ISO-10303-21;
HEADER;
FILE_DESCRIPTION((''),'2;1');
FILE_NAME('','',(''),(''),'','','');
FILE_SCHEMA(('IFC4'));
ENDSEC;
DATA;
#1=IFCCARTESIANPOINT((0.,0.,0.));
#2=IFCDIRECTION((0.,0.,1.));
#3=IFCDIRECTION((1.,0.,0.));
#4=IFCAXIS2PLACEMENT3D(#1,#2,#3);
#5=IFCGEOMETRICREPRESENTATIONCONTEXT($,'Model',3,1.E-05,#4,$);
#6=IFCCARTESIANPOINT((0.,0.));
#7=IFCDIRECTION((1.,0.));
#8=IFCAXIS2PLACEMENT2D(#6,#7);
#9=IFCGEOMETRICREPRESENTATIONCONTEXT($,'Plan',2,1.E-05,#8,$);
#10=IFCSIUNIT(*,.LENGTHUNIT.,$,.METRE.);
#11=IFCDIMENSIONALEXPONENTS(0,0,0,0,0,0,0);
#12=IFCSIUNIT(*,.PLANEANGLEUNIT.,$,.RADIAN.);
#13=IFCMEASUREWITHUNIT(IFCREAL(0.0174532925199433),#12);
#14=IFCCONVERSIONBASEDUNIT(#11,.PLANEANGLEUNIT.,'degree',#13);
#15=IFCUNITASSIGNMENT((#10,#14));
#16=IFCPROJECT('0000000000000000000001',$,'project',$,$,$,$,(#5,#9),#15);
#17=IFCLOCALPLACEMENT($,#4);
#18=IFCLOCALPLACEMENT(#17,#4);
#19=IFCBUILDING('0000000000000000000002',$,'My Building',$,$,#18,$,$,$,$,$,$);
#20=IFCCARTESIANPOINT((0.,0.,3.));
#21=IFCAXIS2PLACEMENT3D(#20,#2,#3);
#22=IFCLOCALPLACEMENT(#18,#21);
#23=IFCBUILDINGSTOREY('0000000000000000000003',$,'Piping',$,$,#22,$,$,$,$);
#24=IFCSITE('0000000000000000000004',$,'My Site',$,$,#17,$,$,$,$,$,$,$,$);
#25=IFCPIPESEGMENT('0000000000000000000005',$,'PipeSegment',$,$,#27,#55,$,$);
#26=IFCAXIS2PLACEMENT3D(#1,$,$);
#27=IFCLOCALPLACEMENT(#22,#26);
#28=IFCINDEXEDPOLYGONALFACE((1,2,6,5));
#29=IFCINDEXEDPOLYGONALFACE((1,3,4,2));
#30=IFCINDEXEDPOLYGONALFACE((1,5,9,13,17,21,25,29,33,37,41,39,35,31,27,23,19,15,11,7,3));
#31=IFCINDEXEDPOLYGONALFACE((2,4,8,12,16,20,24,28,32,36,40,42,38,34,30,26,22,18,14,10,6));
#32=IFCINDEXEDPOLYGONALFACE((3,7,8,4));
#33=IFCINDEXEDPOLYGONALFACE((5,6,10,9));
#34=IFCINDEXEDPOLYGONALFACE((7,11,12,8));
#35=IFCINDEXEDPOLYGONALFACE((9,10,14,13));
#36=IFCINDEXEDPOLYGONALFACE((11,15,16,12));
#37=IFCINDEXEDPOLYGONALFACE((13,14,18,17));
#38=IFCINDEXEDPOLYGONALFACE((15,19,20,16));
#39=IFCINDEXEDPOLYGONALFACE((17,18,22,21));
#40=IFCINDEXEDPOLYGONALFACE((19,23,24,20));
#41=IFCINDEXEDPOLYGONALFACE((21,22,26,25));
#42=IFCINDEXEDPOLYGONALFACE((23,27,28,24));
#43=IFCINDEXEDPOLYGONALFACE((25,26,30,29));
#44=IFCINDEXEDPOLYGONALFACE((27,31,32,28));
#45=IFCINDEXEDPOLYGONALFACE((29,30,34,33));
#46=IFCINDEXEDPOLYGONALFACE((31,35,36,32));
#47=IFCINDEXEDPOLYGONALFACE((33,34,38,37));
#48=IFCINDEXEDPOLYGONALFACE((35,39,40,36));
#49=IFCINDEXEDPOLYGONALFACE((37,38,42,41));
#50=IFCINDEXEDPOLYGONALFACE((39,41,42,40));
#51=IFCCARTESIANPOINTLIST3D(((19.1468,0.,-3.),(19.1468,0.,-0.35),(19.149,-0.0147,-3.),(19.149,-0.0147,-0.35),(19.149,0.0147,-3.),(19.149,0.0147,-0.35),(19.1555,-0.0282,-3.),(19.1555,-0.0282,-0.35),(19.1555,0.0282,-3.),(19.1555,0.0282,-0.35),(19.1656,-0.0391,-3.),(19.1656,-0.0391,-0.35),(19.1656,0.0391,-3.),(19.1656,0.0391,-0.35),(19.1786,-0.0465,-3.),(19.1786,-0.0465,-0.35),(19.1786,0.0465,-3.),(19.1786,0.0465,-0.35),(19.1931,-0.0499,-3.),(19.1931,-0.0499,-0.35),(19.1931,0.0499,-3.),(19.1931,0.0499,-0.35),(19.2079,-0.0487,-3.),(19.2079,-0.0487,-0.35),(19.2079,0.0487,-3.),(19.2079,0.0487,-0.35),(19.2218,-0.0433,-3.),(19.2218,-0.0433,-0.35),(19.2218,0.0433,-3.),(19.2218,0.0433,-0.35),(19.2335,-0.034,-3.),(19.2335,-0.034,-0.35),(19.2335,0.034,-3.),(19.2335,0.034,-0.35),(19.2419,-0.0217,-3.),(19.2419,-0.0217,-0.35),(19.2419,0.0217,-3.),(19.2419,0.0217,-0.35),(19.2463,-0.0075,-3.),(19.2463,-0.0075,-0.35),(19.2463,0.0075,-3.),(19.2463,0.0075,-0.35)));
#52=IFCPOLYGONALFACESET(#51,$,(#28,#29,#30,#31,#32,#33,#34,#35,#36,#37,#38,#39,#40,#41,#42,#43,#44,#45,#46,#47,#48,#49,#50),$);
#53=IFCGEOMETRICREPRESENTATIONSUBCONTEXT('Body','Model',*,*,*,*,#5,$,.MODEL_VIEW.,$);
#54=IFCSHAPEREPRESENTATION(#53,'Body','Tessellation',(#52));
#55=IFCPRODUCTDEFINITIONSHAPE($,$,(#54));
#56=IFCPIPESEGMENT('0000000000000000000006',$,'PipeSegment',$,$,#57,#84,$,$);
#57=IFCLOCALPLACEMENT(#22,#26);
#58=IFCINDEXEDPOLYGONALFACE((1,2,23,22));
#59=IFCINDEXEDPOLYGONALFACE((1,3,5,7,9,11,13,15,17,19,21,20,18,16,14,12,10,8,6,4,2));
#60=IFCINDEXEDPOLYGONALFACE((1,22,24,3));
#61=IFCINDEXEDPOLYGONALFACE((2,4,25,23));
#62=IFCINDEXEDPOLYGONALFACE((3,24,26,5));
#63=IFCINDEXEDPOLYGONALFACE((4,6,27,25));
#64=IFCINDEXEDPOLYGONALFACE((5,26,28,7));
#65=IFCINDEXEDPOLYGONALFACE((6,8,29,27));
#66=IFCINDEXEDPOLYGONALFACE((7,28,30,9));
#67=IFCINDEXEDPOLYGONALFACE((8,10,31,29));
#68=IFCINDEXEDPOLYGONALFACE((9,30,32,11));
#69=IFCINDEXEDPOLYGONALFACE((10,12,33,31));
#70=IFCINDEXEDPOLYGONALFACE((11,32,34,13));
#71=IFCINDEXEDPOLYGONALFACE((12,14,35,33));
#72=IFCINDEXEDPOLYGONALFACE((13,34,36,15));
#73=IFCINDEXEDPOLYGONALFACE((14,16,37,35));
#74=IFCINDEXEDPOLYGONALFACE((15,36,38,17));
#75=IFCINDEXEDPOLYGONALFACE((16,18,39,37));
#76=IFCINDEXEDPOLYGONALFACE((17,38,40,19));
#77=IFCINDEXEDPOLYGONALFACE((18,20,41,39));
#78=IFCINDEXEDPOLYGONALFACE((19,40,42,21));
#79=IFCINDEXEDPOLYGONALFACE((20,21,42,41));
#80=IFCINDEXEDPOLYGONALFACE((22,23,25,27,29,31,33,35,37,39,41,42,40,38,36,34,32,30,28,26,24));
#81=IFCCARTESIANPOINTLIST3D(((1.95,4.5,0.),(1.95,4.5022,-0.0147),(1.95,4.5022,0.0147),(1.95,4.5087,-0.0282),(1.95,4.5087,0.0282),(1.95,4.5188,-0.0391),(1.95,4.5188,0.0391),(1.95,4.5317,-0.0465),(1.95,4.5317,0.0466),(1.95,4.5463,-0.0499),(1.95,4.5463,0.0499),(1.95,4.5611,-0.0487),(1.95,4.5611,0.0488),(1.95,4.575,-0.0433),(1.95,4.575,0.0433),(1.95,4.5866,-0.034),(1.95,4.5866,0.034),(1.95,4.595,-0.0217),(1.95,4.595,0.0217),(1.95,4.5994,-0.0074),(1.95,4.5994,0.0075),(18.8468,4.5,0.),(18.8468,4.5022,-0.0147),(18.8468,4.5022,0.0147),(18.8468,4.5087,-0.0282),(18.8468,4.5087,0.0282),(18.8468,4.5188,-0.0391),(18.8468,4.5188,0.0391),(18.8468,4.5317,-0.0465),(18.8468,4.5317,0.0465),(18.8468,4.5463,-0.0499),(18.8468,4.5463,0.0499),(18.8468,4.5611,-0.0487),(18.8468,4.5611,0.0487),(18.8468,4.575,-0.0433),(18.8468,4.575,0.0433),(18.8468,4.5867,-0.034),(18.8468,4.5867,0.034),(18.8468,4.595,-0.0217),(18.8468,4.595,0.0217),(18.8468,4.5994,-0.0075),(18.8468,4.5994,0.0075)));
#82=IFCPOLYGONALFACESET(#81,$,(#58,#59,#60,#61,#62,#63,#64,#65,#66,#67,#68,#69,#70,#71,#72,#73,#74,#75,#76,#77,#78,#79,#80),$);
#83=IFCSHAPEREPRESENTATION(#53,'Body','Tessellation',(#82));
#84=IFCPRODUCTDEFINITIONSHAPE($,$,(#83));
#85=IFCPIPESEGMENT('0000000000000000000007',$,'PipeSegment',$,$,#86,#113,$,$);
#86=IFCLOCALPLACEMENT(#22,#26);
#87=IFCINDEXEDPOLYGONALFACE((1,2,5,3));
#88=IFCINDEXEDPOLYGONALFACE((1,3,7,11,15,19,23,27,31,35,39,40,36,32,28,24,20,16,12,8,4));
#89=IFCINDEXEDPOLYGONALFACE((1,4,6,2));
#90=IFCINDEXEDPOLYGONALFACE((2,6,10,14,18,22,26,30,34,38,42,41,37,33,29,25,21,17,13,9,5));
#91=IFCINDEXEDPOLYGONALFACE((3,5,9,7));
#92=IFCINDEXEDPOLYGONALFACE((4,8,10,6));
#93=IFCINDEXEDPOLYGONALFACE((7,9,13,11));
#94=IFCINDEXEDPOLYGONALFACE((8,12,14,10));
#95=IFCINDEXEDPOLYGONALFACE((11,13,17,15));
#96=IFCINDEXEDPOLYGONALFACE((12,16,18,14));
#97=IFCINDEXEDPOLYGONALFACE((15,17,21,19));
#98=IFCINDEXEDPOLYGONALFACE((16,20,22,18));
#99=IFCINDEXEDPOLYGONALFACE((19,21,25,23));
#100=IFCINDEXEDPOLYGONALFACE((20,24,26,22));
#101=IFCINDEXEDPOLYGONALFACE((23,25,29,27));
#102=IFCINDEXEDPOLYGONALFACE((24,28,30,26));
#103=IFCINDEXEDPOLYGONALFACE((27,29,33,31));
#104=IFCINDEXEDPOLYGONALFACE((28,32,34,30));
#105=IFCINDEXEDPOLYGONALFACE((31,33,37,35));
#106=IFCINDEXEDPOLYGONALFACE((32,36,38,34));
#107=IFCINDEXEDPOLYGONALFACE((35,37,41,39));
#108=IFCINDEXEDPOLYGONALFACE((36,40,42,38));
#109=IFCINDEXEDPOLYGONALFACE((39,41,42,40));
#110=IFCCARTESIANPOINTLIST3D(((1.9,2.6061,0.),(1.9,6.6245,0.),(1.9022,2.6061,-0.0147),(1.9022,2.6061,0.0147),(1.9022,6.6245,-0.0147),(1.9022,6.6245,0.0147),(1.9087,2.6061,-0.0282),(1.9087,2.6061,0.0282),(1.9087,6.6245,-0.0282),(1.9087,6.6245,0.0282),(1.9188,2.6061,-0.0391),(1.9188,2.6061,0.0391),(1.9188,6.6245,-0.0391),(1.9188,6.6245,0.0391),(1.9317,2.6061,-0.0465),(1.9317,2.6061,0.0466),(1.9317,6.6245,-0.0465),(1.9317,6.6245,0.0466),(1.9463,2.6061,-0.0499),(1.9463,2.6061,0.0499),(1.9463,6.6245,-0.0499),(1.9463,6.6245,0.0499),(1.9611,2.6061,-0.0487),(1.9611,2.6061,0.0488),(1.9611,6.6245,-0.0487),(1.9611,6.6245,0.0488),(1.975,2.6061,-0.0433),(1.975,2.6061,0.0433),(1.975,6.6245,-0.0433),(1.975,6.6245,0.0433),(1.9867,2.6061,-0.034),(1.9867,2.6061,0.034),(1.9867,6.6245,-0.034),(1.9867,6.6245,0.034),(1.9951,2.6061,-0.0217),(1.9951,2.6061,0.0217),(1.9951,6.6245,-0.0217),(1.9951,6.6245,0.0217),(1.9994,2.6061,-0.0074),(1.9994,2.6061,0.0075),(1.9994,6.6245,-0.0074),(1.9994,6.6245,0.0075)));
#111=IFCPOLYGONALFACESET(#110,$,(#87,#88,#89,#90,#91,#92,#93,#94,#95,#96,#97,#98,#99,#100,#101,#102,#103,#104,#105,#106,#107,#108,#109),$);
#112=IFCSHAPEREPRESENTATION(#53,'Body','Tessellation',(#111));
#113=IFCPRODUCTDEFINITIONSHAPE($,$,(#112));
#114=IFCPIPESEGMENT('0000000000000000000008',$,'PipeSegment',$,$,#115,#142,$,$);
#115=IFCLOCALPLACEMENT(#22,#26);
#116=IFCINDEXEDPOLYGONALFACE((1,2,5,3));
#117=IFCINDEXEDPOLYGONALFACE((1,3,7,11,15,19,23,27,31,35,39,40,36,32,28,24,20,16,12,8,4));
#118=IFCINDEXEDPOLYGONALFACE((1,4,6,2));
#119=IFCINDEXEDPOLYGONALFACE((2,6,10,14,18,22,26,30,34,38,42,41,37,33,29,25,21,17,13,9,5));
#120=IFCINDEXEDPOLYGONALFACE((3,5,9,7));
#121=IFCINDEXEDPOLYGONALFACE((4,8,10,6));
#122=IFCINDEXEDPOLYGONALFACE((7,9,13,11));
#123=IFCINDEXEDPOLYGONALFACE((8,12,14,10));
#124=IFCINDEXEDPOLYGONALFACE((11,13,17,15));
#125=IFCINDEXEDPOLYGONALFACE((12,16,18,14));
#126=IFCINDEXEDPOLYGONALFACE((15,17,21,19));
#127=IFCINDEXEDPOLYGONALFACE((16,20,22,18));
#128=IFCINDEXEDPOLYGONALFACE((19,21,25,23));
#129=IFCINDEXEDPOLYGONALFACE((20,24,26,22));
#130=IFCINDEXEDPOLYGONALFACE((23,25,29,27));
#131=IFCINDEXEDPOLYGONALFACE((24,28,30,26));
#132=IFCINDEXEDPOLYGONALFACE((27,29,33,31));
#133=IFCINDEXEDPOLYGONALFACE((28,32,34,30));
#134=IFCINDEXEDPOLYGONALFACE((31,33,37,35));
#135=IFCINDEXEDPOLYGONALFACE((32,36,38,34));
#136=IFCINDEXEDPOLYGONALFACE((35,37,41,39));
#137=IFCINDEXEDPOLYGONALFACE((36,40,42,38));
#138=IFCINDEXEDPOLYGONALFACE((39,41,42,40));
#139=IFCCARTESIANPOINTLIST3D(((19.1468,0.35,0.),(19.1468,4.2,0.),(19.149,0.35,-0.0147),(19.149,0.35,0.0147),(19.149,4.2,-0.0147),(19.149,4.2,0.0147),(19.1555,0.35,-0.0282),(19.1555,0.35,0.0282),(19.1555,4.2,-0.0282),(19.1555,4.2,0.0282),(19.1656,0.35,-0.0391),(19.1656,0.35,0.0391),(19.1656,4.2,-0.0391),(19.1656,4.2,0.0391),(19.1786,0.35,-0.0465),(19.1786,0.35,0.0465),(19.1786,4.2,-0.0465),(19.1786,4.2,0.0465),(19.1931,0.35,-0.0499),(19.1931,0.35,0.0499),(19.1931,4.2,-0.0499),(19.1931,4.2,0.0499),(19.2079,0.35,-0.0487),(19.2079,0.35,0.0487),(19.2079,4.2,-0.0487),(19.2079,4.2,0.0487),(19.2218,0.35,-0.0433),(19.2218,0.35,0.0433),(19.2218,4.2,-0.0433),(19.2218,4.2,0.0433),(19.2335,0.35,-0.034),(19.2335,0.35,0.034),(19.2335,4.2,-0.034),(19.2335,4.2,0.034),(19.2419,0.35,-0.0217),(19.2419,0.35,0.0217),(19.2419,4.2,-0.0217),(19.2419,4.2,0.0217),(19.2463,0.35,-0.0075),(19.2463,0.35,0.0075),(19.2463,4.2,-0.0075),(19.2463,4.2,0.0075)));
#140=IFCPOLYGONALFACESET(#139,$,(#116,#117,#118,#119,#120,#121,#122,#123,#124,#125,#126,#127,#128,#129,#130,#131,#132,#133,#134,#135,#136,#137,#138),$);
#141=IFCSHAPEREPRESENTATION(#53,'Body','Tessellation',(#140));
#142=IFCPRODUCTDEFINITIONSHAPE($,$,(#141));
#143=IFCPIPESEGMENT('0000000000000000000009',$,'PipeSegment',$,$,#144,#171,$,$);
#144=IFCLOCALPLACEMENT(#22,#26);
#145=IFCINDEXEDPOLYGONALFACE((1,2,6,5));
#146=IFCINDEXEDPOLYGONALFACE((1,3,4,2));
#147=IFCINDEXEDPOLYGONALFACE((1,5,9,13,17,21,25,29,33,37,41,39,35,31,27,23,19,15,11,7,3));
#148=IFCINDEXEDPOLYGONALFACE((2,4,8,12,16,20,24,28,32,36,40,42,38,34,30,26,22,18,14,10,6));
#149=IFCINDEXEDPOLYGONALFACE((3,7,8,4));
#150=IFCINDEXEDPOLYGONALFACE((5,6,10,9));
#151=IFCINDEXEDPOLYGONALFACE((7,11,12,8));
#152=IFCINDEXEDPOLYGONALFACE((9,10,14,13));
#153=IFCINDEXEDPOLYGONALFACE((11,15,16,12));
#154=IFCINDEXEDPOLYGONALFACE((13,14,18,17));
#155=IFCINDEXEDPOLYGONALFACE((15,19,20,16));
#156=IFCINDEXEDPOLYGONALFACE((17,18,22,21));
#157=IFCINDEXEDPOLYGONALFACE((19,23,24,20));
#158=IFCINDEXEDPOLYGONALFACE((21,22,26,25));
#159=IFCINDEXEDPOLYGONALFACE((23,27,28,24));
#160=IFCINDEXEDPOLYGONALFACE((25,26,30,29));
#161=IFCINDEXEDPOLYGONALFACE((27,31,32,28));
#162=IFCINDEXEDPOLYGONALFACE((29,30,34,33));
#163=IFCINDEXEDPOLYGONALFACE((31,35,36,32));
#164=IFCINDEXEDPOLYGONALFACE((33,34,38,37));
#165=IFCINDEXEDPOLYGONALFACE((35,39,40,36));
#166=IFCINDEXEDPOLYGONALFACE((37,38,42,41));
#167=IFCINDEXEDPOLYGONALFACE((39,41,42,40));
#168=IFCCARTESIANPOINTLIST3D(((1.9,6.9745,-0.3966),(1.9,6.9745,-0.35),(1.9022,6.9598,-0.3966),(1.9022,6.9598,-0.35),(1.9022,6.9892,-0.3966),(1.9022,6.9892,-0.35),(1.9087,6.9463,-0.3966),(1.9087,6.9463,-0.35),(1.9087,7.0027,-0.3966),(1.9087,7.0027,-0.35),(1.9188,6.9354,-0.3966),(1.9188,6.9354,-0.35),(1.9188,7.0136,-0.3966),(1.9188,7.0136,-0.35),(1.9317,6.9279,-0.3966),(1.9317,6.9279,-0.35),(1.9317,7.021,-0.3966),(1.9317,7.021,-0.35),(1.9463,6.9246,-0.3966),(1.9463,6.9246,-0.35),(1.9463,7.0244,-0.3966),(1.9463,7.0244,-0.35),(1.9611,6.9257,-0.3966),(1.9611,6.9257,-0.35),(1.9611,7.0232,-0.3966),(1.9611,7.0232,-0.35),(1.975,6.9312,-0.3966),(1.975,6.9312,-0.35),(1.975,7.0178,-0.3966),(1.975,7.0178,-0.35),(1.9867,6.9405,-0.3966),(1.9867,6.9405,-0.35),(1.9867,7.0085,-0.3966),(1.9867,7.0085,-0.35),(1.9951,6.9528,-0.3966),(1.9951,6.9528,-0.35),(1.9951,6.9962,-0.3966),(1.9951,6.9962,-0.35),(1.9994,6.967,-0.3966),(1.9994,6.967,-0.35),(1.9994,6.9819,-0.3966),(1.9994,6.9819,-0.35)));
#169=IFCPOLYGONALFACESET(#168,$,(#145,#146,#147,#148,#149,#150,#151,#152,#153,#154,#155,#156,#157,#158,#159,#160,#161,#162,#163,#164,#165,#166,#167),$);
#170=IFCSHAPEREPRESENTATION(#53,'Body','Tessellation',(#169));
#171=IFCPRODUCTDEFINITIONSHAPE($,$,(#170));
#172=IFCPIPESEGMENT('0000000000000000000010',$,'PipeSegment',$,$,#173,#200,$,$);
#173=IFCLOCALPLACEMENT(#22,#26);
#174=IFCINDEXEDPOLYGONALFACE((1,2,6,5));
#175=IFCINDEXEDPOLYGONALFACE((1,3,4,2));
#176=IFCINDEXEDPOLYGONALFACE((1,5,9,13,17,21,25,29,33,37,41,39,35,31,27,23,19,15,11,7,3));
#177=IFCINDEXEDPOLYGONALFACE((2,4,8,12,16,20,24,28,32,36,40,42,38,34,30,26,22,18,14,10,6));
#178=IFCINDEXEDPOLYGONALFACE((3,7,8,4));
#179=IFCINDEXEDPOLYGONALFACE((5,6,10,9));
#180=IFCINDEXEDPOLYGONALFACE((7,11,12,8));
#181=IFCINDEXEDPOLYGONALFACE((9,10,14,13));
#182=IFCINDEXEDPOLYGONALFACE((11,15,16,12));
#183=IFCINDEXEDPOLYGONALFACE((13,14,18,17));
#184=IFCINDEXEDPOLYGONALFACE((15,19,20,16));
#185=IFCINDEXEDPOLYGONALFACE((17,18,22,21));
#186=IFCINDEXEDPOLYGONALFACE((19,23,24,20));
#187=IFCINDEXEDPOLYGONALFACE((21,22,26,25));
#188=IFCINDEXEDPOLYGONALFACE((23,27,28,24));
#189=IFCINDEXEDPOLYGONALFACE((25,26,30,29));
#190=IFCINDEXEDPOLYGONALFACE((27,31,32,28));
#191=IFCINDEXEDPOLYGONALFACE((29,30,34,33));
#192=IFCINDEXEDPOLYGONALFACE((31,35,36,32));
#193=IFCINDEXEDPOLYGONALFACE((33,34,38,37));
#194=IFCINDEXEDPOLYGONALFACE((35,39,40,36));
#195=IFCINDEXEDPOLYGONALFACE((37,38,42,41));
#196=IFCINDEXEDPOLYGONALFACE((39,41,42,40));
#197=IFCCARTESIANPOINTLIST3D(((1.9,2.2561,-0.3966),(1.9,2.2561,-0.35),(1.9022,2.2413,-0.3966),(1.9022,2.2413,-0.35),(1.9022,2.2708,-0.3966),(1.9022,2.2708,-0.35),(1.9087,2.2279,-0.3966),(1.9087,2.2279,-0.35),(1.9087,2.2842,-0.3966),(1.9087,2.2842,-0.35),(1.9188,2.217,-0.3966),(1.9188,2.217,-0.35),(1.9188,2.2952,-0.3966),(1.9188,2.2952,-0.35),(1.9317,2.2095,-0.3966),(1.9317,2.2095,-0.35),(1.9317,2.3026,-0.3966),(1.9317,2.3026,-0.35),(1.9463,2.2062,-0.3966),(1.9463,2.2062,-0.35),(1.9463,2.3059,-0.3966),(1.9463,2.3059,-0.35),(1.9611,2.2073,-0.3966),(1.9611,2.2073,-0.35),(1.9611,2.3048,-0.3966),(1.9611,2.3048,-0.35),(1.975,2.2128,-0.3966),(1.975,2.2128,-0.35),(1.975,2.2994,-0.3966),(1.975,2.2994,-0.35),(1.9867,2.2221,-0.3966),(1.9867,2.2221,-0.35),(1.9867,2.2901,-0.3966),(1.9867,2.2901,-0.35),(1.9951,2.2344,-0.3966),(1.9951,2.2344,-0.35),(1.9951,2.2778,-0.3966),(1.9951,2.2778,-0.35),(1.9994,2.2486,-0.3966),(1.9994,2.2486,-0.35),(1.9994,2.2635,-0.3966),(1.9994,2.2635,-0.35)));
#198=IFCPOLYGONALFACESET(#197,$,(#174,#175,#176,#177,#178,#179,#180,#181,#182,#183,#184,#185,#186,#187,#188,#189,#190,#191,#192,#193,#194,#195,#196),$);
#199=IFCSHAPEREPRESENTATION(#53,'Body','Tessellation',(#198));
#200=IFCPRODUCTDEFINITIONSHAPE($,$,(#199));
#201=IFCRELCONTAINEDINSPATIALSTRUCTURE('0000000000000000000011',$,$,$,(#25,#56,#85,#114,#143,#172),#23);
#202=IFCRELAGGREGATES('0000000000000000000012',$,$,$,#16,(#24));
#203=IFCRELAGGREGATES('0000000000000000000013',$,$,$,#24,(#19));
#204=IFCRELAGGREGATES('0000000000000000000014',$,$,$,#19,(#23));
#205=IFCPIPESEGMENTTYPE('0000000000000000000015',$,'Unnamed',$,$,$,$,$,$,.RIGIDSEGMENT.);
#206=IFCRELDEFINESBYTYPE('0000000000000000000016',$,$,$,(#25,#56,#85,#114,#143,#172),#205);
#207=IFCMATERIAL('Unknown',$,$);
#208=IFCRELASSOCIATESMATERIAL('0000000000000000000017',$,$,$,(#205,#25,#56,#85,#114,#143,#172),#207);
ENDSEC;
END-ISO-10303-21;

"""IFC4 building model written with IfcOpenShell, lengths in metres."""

from ifc_helpers import new_model, entity, si_unit, converted_unit, frame, origin_with_axes, origin_2d_with_axis, place, context, subcontext, project, spatial, circle, extrude, material, material_profile, profile_set, profile_usage, type_object, element, save


model = new_model("IFC4")

# Units and contexts
model_context = context("Model", 3, precision=1e-05, world=origin_with_axes())
plan_context = context("Plan", 2, precision=1e-05, world=origin_2d_with_axis())
body_context = subcontext(model_context, "Body", "Model", "MODEL_VIEW")
ifc_project = project(units=[si_unit("LENGTHUNIT", "METRE"), converted_unit("PLANEANGLEUNIT", "degree", entity("IfcReal", 0.0174532925199433), si_unit("PLANEANGLEUNIT", "RADIAN"), dimensions=[0, 0, 0, 0, 0, 0, 0])], contexts=[model_context, plan_context])

# Site, building, storey
site_placement = place(None, origin_with_axes())
site = spatial("IfcSite", under=ifc_project, at=site_placement, Name="My Site")
building_placement = place(site_placement, origin_with_axes())
building = spatial("IfcBuilding", under=site, at=building_placement, Name="My Building")
storey_placement = place(building_placement, frame((0.0, 0.0, 3.0), z_axis=(0.0, 0.0, 1.0), x_axis=(1.0, 0.0, 0.0)))
storey = spatial("IfcBuildingStorey", under=building, at=storey_placement, Name="Piping")

# Pipe segments
ifc_material = material(Name="Unknown")
ifc_material_profile = material_profile(ifc_material, circle(Radius=0.05))
ifc_profile_set = profile_set([ifc_material_profile])
ifc_profile_usage_1 = profile_usage(ifc_profile_set, cardinal=5)
pipe_segment_type = type_object("IfcPipeSegmentType", Name="Unnamed", PredefinedType="RIGIDSEGMENT", material=ifc_profile_set)
pipe_segment_1_placement = place(storey_placement, frame((19.1968, 0.0, -3.0), z_axis=(0.0, 0.0, 1.0), x_axis=(-1.0, 0.0, 0.0)))
element("IfcPipeSegment", 1, at=pipe_segment_1_placement, inside=storey, type_object=pipe_segment_type, material=ifc_profile_usage_1, Name="PipeSegment", context=body_context, shape_type="SweptSolid", body=[
    extrude(circle(Radius=0.05), origin_with_axes(), (0.0, 0.0, 1.0), 2.65),
])
ifc_profile_usage_2 = profile_usage(ifc_profile_set, cardinal=5)
pipe_segment_2_placement = place(storey_placement, frame((18.8468, 4.55, 0.0), z_axis=(-1.0, -0.000001, 0.0), x_axis=(0.000001, -1.0, 0.0)))
element("IfcPipeSegment", 2, at=pipe_segment_2_placement, inside=storey, type_object=pipe_segment_type, material=ifc_profile_usage_2, Name="PipeSegment", context=body_context, shape_type="SweptSolid", body=[
    extrude(circle(Radius=0.05), origin_with_axes(), (0.0, 0.0, 1.0), 16.8968),
])
ifc_profile_usage_3 = profile_usage(ifc_profile_set, cardinal=5)
pipe_segment_3_placement = place(storey_placement, frame((1.95, 2.6061, 0.0), z_axis=(0.0, 1.0, 0.0), x_axis=(-1.0, 0.0, 0.0)))
element("IfcPipeSegment", 3, at=pipe_segment_3_placement, inside=storey, type_object=pipe_segment_type, material=ifc_profile_usage_3, Name="PipeSegment", context=body_context, shape_type="SweptSolid", body=[
    extrude(circle(Radius=0.05), origin_with_axes(), (0.0, 0.0, 1.0), 4.0184),
])
ifc_profile_usage_4 = profile_usage(ifc_profile_set, cardinal=5)
pipe_segment_4_placement = place(storey_placement, frame((19.1968, 0.35, 0.0), z_axis=(0.0, 1.0, 0.0), x_axis=(-1.0, 0.0, 0.0)))
element("IfcPipeSegment", 4, at=pipe_segment_4_placement, inside=storey, type_object=pipe_segment_type, material=ifc_profile_usage_4, Name="PipeSegment", context=body_context, shape_type="SweptSolid", body=[
    extrude(circle(Radius=0.05), origin_with_axes(), (0.0, 0.0, 1.0), 3.85),
])
ifc_profile_usage_5 = profile_usage(ifc_profile_set, cardinal=5)
pipe_segment_5_placement = place(storey_placement, frame((1.95, 6.9745, -0.35), z_axis=(0.0, 0.0, -1.0), x_axis=(-1.0, 0.0, 0.0)))
element("IfcPipeSegment", 5, at=pipe_segment_5_placement, inside=storey, type_object=pipe_segment_type, material=ifc_profile_usage_5, Name="PipeSegment", context=body_context, shape_type="SweptSolid", body=[
    extrude(circle(Radius=0.05), origin_with_axes(), (0.0, 0.0, 1.0), 0.0467),
])
ifc_profile_usage_6 = profile_usage(ifc_profile_set, cardinal=5)
pipe_segment_6_placement = place(storey_placement, frame((1.95, 2.2561, -0.35), z_axis=(0.0, 0.0, -1.0), x_axis=(-1.0, 0.0, 0.0)))
element("IfcPipeSegment", 6, at=pipe_segment_6_placement, inside=storey, type_object=pipe_segment_type, material=ifc_profile_usage_6, Name="PipeSegment", context=body_context, shape_type="SweptSolid", body=[
    extrude(circle(Radius=0.05), origin_with_axes(), (0.0, 0.0, 1.0), 0.0467),
])

save(model, "model.ifc")
